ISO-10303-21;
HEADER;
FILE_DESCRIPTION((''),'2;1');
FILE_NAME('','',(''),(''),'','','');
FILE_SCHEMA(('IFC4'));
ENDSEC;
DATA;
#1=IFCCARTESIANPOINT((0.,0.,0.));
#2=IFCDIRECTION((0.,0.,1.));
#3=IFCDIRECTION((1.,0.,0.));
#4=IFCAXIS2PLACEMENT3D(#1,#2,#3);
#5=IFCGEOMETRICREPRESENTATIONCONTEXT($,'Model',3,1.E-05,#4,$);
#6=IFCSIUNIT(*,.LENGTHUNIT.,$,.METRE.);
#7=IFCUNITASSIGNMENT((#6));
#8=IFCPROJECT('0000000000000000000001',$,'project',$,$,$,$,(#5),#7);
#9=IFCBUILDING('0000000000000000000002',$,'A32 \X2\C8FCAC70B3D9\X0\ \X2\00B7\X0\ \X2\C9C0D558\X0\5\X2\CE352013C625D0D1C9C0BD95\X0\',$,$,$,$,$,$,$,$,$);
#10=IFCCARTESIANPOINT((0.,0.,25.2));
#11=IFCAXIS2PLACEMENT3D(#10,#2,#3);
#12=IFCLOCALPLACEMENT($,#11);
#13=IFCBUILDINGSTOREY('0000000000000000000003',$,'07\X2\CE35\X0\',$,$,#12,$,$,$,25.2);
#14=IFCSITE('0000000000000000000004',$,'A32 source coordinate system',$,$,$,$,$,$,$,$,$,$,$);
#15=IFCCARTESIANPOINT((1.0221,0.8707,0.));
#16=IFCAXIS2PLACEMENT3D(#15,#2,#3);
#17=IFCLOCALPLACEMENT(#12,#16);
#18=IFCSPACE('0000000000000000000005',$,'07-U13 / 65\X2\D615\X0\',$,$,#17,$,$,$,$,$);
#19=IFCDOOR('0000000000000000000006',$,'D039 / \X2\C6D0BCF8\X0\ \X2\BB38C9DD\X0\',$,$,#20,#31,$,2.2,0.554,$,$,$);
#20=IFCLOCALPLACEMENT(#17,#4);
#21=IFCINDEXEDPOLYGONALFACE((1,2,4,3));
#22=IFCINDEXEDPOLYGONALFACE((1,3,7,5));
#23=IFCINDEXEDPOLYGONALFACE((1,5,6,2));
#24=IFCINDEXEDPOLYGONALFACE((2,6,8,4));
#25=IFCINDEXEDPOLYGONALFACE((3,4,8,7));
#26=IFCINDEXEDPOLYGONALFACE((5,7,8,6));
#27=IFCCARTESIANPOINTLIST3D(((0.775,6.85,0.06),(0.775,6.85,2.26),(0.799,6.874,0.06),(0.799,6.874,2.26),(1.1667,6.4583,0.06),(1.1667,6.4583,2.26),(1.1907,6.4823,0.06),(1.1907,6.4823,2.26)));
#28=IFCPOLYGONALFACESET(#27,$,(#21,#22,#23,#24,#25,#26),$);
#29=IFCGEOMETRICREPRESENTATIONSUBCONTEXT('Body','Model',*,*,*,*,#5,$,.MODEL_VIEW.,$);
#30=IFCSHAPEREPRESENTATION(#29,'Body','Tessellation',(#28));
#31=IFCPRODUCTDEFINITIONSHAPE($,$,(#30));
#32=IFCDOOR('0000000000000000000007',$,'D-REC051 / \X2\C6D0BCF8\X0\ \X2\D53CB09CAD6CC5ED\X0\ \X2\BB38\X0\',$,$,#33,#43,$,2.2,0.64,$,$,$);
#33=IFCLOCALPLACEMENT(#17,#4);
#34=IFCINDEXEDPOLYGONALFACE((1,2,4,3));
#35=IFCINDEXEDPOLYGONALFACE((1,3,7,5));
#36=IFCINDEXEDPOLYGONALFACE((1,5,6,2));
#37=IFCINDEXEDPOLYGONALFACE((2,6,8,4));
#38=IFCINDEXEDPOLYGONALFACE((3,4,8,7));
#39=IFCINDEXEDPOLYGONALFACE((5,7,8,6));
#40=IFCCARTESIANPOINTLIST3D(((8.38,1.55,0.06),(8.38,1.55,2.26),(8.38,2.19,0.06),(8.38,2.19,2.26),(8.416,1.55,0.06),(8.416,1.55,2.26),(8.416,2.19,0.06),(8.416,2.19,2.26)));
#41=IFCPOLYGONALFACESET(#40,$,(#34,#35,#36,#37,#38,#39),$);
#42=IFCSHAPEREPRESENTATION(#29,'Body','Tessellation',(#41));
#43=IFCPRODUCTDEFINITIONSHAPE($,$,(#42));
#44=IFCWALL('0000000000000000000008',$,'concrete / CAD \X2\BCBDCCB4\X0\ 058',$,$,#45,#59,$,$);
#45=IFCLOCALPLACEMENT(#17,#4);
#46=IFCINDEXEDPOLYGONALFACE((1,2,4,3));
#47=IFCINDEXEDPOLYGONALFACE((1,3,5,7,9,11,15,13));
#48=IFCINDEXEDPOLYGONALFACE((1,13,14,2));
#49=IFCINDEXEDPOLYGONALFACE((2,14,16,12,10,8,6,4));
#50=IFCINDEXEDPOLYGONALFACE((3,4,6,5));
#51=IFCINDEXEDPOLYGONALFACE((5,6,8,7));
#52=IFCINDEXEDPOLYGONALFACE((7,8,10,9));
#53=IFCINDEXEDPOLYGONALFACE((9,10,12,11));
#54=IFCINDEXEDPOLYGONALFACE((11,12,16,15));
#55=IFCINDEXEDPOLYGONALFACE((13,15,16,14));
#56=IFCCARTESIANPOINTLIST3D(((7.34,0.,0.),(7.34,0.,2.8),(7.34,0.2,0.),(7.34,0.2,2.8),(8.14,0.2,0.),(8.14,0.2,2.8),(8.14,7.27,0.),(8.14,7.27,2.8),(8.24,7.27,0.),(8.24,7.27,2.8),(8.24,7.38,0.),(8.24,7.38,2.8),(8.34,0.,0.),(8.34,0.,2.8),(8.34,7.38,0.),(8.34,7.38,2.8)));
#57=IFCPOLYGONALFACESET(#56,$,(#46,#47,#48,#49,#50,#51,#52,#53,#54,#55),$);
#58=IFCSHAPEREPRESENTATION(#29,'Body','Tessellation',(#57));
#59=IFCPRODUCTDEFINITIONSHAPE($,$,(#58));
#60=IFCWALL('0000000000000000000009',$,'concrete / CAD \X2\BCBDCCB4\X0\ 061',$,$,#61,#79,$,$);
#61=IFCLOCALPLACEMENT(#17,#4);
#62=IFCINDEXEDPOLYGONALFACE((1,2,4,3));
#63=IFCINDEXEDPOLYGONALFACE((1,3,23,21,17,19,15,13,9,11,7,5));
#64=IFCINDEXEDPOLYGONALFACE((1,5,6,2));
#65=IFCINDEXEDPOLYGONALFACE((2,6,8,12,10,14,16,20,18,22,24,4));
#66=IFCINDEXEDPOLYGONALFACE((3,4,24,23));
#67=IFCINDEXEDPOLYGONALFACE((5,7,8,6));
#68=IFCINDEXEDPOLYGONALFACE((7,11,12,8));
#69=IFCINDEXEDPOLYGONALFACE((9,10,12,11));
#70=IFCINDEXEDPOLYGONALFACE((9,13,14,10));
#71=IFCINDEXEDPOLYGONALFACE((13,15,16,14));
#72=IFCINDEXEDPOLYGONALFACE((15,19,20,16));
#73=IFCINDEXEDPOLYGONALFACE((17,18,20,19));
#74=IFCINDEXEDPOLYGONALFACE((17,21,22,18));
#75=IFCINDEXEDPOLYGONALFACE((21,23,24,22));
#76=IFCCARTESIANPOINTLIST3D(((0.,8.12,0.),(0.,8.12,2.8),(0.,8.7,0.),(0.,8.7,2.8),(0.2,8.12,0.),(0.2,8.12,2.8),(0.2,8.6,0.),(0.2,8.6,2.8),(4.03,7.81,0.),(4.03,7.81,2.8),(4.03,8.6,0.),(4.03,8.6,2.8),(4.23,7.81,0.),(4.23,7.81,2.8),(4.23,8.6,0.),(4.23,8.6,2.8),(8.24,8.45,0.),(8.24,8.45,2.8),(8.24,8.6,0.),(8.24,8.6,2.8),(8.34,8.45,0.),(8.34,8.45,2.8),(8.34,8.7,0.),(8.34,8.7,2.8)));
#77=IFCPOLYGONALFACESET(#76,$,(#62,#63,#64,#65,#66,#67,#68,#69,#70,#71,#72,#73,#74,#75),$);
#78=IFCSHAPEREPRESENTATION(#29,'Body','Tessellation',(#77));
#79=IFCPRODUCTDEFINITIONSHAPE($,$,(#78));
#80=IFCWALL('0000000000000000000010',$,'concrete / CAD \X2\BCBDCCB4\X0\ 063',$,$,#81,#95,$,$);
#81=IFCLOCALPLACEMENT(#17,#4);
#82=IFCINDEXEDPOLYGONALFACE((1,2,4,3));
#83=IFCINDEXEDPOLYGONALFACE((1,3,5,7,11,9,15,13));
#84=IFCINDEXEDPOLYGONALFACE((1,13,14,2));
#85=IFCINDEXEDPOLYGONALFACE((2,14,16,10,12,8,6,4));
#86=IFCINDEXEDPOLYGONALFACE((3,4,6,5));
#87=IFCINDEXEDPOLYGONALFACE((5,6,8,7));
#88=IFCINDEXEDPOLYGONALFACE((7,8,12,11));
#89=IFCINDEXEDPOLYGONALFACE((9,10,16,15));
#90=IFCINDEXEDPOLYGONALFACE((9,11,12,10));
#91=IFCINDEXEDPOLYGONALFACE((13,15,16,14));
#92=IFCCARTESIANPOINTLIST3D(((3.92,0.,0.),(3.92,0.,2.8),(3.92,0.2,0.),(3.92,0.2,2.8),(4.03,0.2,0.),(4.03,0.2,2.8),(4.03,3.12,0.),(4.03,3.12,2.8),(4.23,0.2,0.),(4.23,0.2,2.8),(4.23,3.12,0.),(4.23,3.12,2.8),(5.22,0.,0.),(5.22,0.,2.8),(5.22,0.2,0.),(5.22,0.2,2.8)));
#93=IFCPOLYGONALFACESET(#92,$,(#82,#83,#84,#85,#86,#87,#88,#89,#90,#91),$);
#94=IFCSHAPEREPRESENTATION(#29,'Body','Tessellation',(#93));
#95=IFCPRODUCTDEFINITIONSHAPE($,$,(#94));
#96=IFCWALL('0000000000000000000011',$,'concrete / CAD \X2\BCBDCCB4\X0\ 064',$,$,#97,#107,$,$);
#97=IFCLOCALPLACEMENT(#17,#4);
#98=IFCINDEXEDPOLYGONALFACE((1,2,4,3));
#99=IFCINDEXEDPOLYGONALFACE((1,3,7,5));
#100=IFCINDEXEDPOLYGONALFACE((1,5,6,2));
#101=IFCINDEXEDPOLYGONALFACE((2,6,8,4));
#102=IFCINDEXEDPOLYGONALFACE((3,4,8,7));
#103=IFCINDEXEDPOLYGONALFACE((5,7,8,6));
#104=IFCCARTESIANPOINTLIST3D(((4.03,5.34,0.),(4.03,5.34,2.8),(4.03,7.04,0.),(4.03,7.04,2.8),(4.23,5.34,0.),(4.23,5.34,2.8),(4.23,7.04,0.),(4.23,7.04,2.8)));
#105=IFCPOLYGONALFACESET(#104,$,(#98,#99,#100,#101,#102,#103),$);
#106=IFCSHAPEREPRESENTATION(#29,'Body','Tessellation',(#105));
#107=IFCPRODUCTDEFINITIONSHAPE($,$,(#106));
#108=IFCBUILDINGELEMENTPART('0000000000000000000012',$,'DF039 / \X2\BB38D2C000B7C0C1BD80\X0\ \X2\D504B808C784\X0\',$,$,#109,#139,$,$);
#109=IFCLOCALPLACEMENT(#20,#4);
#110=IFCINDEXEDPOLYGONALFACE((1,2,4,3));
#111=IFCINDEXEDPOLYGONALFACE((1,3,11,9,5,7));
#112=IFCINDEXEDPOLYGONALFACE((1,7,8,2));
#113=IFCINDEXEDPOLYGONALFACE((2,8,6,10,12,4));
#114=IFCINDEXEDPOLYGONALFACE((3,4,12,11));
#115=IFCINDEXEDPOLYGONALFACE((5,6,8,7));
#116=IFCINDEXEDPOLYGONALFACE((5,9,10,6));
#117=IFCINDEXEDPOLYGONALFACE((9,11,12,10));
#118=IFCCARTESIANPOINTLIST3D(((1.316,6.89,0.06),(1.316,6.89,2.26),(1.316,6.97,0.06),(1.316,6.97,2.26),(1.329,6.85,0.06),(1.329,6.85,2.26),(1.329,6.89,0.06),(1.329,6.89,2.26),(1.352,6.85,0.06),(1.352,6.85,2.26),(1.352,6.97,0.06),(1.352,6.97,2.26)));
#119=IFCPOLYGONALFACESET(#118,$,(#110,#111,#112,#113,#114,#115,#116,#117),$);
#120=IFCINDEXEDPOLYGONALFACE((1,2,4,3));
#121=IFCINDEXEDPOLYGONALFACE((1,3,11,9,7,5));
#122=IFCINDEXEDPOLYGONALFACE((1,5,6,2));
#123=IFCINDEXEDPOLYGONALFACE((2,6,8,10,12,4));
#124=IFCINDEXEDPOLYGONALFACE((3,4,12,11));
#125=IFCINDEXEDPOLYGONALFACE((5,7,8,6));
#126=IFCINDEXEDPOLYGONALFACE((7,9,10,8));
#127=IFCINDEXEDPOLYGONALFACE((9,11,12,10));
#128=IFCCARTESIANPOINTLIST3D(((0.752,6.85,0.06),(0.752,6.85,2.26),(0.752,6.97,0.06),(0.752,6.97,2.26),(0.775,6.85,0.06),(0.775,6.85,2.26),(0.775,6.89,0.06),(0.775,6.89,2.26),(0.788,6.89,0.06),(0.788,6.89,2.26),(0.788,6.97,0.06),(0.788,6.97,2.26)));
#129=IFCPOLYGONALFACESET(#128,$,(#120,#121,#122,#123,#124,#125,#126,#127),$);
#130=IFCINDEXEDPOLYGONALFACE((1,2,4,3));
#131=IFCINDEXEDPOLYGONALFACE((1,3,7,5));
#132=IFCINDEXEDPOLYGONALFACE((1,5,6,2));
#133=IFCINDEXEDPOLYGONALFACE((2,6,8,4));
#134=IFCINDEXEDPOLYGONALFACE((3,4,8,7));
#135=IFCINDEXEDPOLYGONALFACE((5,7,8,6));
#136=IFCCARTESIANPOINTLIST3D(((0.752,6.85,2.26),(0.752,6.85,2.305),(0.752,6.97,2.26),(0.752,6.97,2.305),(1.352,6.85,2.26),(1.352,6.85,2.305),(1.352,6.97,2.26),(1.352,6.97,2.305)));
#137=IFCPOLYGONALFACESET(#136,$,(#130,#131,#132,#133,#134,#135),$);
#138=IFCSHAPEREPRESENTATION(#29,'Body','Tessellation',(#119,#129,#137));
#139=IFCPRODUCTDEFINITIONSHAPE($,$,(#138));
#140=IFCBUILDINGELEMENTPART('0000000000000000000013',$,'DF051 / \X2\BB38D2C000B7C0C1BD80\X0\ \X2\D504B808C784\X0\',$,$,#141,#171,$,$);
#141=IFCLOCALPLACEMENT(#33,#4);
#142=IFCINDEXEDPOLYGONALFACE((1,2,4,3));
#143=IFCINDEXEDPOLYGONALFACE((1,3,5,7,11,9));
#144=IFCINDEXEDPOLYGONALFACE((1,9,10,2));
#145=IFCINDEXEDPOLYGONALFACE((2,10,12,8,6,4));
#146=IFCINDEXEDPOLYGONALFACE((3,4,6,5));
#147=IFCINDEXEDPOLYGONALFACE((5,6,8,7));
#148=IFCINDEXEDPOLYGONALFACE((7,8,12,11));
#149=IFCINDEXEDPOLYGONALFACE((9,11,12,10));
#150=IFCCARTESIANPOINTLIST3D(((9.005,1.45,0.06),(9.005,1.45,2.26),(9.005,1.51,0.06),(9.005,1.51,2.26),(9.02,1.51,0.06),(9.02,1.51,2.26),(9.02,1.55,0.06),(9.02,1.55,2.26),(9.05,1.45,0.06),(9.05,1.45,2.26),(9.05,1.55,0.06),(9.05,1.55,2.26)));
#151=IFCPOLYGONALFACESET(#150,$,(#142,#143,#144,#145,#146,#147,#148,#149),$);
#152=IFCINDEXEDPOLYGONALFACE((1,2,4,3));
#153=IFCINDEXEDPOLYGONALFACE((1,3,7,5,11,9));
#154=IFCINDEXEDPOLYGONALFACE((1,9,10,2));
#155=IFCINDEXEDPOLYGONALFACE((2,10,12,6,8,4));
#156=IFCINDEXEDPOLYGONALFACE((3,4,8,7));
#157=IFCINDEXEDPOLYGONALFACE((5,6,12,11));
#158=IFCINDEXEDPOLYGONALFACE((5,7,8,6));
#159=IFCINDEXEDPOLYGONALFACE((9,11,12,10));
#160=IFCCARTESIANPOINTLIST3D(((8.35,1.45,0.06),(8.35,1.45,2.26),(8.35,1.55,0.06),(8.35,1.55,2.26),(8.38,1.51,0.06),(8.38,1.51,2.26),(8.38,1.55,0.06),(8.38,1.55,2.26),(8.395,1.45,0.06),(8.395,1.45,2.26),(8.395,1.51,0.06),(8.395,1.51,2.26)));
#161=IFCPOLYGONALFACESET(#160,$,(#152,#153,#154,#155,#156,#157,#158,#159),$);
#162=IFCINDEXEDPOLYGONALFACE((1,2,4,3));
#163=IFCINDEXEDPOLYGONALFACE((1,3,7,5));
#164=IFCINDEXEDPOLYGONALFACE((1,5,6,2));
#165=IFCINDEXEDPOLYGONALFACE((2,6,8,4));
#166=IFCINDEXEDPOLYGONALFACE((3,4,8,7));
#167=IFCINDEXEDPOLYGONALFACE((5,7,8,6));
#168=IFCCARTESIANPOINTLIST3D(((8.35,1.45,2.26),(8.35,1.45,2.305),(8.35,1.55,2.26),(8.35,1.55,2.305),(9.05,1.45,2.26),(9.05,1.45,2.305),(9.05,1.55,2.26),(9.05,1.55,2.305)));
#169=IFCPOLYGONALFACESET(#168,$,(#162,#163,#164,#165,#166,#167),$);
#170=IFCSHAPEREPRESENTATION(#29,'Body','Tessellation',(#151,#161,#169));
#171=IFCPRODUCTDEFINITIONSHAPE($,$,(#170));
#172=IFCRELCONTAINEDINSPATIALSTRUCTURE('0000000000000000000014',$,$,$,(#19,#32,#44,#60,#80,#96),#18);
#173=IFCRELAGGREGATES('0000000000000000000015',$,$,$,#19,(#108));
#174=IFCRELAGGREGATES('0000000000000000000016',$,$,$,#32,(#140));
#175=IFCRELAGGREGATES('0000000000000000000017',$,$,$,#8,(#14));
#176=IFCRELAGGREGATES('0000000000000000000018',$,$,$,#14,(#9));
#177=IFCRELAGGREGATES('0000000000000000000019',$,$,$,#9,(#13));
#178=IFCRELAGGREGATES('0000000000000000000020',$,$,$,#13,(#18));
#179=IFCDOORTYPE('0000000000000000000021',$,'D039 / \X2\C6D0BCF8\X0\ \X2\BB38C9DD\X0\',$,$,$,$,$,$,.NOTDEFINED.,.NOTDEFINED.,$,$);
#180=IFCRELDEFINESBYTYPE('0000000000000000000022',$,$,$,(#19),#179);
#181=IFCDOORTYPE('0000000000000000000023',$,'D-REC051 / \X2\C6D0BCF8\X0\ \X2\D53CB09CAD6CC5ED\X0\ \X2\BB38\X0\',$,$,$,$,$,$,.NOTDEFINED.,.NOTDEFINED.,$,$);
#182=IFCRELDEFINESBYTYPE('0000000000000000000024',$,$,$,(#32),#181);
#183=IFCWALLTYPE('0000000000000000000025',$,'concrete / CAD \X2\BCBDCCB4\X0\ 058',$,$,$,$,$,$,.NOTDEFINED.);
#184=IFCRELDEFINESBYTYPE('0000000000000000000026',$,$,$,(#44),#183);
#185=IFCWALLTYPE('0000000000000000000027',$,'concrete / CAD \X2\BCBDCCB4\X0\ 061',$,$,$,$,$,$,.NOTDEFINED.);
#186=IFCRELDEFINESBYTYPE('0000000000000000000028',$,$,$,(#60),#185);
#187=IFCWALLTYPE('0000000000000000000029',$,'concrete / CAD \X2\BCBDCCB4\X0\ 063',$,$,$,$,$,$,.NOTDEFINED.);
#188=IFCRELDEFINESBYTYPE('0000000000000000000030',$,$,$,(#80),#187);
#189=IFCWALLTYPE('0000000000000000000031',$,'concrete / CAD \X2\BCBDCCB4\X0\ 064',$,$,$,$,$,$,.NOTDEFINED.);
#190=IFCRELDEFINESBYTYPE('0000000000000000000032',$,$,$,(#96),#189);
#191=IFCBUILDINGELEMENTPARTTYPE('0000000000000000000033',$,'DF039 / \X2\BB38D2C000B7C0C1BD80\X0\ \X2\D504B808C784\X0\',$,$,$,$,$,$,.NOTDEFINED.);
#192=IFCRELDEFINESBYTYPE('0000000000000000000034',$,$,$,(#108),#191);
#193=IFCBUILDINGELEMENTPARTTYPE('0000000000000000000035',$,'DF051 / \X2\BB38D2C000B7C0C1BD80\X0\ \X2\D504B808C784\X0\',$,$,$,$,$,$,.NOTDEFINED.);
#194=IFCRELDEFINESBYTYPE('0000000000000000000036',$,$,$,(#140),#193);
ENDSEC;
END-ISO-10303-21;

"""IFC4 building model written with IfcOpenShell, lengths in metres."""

from ifc_helpers import new_model, si_unit, frame, origin, origin_with_axes, place, context, subcontext, project, spatial, polyline, outline, extrude, source, transform, mapped, type_object, type_shapes, element, aggregate, save


model = new_model("IFC4")

# Units and contexts
model_context = context("Model", 3, precision=1e-05, world=origin_with_axes())
body_context = subcontext(model_context, "Body", "Model", "MODEL_VIEW")
ifc_project = project(units=[si_unit("LENGTHUNIT", "METRE")], contexts=[model_context])

# Site, building, storey, space
storey_placement = place(None, frame((0.0, 0.0, 25.2), z_axis=(0.0, 0.0, 1.0), x_axis=(1.0, 0.0, 0.0)))
space_placement = place(storey_placement, frame((1.0221, 0.8707, 0.0), z_axis=(0.0, 0.0, 1.0), x_axis=(1.0, 0.0, 0.0)))
site = spatial("IfcSite", under=ifc_project, Name="A32 source coordinate system")
building = spatial("IfcBuilding", under=site, Name="A32 주거동 · 지하5층–옥탑지붕")
storey = spatial("IfcBuildingStorey", under=building, at=storey_placement, Name="07층", Elevation=25.2)
space = spatial("IfcSpace", under=storey, at=space_placement, Name="07-U13 / 65형")

# Doors
door_type_1 = type_object("IfcDoorType", Name="D039 / 원본 문짝", OperationType="NOTDEFINED", PredefinedType="NOTDEFINED")
shared_shape_1 = source(origin(), body_context, "Body", "SweptSolid", [
    extrude(outline(polyline([(1.1907, 6.4823), (1.1667, 6.4583), (0.775, 6.85), (0.799, 6.874), (1.1907, 6.4823)])), frame((0.0, 0.0, 0.06)), (0.0, 0.0, 1.0), 2.2),
])
type_shapes(door_type_1, [shared_shape_1])
door_1_placement = place(space_placement, origin_with_axes())
door_1 = element("IfcDoor", 1, at=door_1_placement, inside=space, type_object=door_type_1, Name="D039 / 원본 문짝", OverallHeight=2.2, OverallWidth=0.554, context=body_context, shape_type="MappedRepresentation", body=[
    mapped(shared_shape_1, transform((0.0, 0.0, 0.0), scale=1.0)),
])
door_type_2 = type_object("IfcDoorType", Name="D-REC051 / 원본 피난구역 문", OperationType="NOTDEFINED", PredefinedType="NOTDEFINED")
shared_shape_2 = source(origin(), body_context, "Body", "SweptSolid", [
    extrude(outline(polyline([(8.416, 2.19), (8.416, 1.55), (8.38, 1.55), (8.38, 2.19), (8.416, 2.19)])), frame((0.0, 0.0, 0.06)), (0.0, 0.0, 1.0), 2.2),
])
type_shapes(door_type_2, [shared_shape_2])
door_2_placement = place(space_placement, origin_with_axes())
door_2 = element("IfcDoor", 2, at=door_2_placement, inside=space, type_object=door_type_2, Name="D-REC051 / 원본 피난구역 문", OverallHeight=2.2, OverallWidth=0.64, context=body_context, shape_type="MappedRepresentation", body=[
    mapped(shared_shape_2, transform((0.0, 0.0, 0.0), scale=1.0)),
])

# Walls
wall_type_1 = type_object("IfcWallType", Name="concrete / CAD 벽체 058", PredefinedType="NOTDEFINED")
shared_shape_3 = source(origin(), body_context, "Body", "SweptSolid", [
    extrude(outline(polyline([(8.34, 0.0), (7.34, 0.0), (7.34, 0.2), (8.14, 0.2), (8.14, 7.27), (8.24, 7.27), (8.24, 7.38), (8.34, 7.38), (8.34, 0.0)])), origin(), (0.0, 0.0, 1.0), 2.8),
])
type_shapes(wall_type_1, [shared_shape_3])
wall_1_placement = place(space_placement, origin_with_axes())
element("IfcWall", 3, at=wall_1_placement, inside=space, type_object=wall_type_1, Name="concrete / CAD 벽체 058", context=body_context, shape_type="MappedRepresentation", body=[
    mapped(shared_shape_3, transform((0.0, 0.0, 0.0), scale=1.0)),
])
wall_type_2 = type_object("IfcWallType", Name="concrete / CAD 벽체 061", PredefinedType="NOTDEFINED")
shared_shape_4 = source(origin(), body_context, "Body", "SweptSolid", [
    extrude(outline(polyline([(0.2, 8.6), (0.2, 8.12), (0.0, 8.12), (0.0, 8.7), (8.34, 8.7), (8.34, 8.45), (8.24, 8.45), (8.24, 8.6), (4.23, 8.6), (4.23, 7.81), (4.03, 7.81), (4.03, 8.6), (0.2, 8.6)])), origin(), (0.0, 0.0, 1.0), 2.8),
])
type_shapes(wall_type_2, [shared_shape_4])
wall_2_placement = place(space_placement, origin_with_axes())
element("IfcWall", 4, at=wall_2_placement, inside=space, type_object=wall_type_2, Name="concrete / CAD 벽체 061", context=body_context, shape_type="MappedRepresentation", body=[
    mapped(shared_shape_4, transform((0.0, 0.0, 0.0), scale=1.0)),
])
wall_type_3 = type_object("IfcWallType", Name="concrete / CAD 벽체 063", PredefinedType="NOTDEFINED")
shared_shape_5 = source(origin(), body_context, "Body", "SweptSolid", [
    extrude(outline(polyline([(5.22, 0.0), (3.92, 0.0), (3.92, 0.2), (4.03, 0.2), (4.03, 3.12), (4.23, 3.12), (4.23, 0.2), (5.22, 0.2), (5.22, 0.0)])), origin(), (0.0, 0.0, 1.0), 2.8),
])
type_shapes(wall_type_3, [shared_shape_5])
wall_3_placement = place(space_placement, origin_with_axes())
element("IfcWall", 5, at=wall_3_placement, inside=space, type_object=wall_type_3, Name="concrete / CAD 벽체 063", context=body_context, shape_type="MappedRepresentation", body=[
    mapped(shared_shape_5, transform((0.0, 0.0, 0.0), scale=1.0)),
])
wall_type_4 = type_object("IfcWallType", Name="concrete / CAD 벽체 064", PredefinedType="NOTDEFINED")
shared_shape_6 = source(origin(), body_context, "Body", "SweptSolid", [
    extrude(outline(polyline([(4.03, 7.04), (4.23, 7.04), (4.23, 5.34), (4.03, 5.34), (4.03, 7.04)])), origin(), (0.0, 0.0, 1.0), 2.8),
])
type_shapes(wall_type_4, [shared_shape_6])
wall_4_placement = place(space_placement, origin_with_axes())
element("IfcWall", 6, at=wall_4_placement, inside=space, type_object=wall_type_4, Name="concrete / CAD 벽체 064", context=body_context, shape_type="MappedRepresentation", body=[
    mapped(shared_shape_6, transform((0.0, 0.0, 0.0), scale=1.0)),
])

# Building element parts
building_element_part_type_1 = type_object("IfcBuildingElementPartType", Name="DF039 / 문틀·상부 프레임", PredefinedType="NOTDEFINED")
shared_shape_7 = source(origin(), body_context, "Body", "SweptSolid", [
    extrude(outline(polyline([(1.352, 6.85), (1.329, 6.85), (1.329, 6.89), (1.316, 6.89), (1.316, 6.97), (1.352, 6.97), (1.352, 6.85)])), frame((0.0, 0.0, 0.06)), (0.0, 0.0, 1.0), 2.2),
    extrude(outline(polyline([(0.788, 6.97), (0.788, 6.89), (0.775, 6.89), (0.775, 6.85), (0.752, 6.85), (0.752, 6.97), (0.788, 6.97)])), frame((0.0, 0.0, 0.06)), (0.0, 0.0, 1.0), 2.2),
    extrude(outline(polyline([(0.752, 6.85), (0.752, 6.97), (1.352, 6.97), (1.352, 6.85), (0.752, 6.85)])), frame((0.0, 0.0, 2.26)), (0.0, 0.0, 1.0), 0.045),
])
type_shapes(building_element_part_type_1, [shared_shape_7])
building_element_part_1_placement = place(door_1_placement, origin_with_axes())
building_element_part_1 = element("IfcBuildingElementPart", 7, at=building_element_part_1_placement, type_object=building_element_part_type_1, Name="DF039 / 문틀·상부 프레임", context=body_context, shape_type="MappedRepresentation", body=[
    mapped(shared_shape_7, transform((0.0, 0.0, 0.0), scale=1.0)),
])
aggregate(door_1, [building_element_part_1])
building_element_part_type_2 = type_object("IfcBuildingElementPartType", Name="DF051 / 문틀·상부 프레임", PredefinedType="NOTDEFINED")
shared_shape_8 = source(origin(), body_context, "Body", "SweptSolid", [
    extrude(outline(polyline([(9.05, 1.45), (9.005, 1.45), (9.005, 1.51), (9.02, 1.51), (9.02, 1.55), (9.05, 1.55), (9.05, 1.45)])), frame((0.0, 0.0, 0.06)), (0.0, 0.0, 1.0), 2.2),
    extrude(outline(polyline([(8.38, 1.55), (8.38, 1.51), (8.395, 1.51), (8.395, 1.45), (8.35, 1.45), (8.35, 1.55), (8.38, 1.55)])), frame((0.0, 0.0, 0.06)), (0.0, 0.0, 1.0), 2.2),
    extrude(outline(polyline([(8.35, 1.45), (8.35, 1.55), (9.05, 1.55), (9.05, 1.45), (8.35, 1.45)])), frame((0.0, 0.0, 2.26)), (0.0, 0.0, 1.0), 0.045),
])
type_shapes(building_element_part_type_2, [shared_shape_8])
building_element_part_2_placement = place(door_2_placement, origin_with_axes())
building_element_part_2 = element("IfcBuildingElementPart", 8, at=building_element_part_2_placement, type_object=building_element_part_type_2, Name="DF051 / 문틀·상부 프레임", context=body_context, shape_type="MappedRepresentation", body=[
    mapped(shared_shape_8, transform((0.0, 0.0, 0.0), scale=1.0)),
])
aggregate(door_2, [building_element_part_2])

save(model, "model.ifc")
